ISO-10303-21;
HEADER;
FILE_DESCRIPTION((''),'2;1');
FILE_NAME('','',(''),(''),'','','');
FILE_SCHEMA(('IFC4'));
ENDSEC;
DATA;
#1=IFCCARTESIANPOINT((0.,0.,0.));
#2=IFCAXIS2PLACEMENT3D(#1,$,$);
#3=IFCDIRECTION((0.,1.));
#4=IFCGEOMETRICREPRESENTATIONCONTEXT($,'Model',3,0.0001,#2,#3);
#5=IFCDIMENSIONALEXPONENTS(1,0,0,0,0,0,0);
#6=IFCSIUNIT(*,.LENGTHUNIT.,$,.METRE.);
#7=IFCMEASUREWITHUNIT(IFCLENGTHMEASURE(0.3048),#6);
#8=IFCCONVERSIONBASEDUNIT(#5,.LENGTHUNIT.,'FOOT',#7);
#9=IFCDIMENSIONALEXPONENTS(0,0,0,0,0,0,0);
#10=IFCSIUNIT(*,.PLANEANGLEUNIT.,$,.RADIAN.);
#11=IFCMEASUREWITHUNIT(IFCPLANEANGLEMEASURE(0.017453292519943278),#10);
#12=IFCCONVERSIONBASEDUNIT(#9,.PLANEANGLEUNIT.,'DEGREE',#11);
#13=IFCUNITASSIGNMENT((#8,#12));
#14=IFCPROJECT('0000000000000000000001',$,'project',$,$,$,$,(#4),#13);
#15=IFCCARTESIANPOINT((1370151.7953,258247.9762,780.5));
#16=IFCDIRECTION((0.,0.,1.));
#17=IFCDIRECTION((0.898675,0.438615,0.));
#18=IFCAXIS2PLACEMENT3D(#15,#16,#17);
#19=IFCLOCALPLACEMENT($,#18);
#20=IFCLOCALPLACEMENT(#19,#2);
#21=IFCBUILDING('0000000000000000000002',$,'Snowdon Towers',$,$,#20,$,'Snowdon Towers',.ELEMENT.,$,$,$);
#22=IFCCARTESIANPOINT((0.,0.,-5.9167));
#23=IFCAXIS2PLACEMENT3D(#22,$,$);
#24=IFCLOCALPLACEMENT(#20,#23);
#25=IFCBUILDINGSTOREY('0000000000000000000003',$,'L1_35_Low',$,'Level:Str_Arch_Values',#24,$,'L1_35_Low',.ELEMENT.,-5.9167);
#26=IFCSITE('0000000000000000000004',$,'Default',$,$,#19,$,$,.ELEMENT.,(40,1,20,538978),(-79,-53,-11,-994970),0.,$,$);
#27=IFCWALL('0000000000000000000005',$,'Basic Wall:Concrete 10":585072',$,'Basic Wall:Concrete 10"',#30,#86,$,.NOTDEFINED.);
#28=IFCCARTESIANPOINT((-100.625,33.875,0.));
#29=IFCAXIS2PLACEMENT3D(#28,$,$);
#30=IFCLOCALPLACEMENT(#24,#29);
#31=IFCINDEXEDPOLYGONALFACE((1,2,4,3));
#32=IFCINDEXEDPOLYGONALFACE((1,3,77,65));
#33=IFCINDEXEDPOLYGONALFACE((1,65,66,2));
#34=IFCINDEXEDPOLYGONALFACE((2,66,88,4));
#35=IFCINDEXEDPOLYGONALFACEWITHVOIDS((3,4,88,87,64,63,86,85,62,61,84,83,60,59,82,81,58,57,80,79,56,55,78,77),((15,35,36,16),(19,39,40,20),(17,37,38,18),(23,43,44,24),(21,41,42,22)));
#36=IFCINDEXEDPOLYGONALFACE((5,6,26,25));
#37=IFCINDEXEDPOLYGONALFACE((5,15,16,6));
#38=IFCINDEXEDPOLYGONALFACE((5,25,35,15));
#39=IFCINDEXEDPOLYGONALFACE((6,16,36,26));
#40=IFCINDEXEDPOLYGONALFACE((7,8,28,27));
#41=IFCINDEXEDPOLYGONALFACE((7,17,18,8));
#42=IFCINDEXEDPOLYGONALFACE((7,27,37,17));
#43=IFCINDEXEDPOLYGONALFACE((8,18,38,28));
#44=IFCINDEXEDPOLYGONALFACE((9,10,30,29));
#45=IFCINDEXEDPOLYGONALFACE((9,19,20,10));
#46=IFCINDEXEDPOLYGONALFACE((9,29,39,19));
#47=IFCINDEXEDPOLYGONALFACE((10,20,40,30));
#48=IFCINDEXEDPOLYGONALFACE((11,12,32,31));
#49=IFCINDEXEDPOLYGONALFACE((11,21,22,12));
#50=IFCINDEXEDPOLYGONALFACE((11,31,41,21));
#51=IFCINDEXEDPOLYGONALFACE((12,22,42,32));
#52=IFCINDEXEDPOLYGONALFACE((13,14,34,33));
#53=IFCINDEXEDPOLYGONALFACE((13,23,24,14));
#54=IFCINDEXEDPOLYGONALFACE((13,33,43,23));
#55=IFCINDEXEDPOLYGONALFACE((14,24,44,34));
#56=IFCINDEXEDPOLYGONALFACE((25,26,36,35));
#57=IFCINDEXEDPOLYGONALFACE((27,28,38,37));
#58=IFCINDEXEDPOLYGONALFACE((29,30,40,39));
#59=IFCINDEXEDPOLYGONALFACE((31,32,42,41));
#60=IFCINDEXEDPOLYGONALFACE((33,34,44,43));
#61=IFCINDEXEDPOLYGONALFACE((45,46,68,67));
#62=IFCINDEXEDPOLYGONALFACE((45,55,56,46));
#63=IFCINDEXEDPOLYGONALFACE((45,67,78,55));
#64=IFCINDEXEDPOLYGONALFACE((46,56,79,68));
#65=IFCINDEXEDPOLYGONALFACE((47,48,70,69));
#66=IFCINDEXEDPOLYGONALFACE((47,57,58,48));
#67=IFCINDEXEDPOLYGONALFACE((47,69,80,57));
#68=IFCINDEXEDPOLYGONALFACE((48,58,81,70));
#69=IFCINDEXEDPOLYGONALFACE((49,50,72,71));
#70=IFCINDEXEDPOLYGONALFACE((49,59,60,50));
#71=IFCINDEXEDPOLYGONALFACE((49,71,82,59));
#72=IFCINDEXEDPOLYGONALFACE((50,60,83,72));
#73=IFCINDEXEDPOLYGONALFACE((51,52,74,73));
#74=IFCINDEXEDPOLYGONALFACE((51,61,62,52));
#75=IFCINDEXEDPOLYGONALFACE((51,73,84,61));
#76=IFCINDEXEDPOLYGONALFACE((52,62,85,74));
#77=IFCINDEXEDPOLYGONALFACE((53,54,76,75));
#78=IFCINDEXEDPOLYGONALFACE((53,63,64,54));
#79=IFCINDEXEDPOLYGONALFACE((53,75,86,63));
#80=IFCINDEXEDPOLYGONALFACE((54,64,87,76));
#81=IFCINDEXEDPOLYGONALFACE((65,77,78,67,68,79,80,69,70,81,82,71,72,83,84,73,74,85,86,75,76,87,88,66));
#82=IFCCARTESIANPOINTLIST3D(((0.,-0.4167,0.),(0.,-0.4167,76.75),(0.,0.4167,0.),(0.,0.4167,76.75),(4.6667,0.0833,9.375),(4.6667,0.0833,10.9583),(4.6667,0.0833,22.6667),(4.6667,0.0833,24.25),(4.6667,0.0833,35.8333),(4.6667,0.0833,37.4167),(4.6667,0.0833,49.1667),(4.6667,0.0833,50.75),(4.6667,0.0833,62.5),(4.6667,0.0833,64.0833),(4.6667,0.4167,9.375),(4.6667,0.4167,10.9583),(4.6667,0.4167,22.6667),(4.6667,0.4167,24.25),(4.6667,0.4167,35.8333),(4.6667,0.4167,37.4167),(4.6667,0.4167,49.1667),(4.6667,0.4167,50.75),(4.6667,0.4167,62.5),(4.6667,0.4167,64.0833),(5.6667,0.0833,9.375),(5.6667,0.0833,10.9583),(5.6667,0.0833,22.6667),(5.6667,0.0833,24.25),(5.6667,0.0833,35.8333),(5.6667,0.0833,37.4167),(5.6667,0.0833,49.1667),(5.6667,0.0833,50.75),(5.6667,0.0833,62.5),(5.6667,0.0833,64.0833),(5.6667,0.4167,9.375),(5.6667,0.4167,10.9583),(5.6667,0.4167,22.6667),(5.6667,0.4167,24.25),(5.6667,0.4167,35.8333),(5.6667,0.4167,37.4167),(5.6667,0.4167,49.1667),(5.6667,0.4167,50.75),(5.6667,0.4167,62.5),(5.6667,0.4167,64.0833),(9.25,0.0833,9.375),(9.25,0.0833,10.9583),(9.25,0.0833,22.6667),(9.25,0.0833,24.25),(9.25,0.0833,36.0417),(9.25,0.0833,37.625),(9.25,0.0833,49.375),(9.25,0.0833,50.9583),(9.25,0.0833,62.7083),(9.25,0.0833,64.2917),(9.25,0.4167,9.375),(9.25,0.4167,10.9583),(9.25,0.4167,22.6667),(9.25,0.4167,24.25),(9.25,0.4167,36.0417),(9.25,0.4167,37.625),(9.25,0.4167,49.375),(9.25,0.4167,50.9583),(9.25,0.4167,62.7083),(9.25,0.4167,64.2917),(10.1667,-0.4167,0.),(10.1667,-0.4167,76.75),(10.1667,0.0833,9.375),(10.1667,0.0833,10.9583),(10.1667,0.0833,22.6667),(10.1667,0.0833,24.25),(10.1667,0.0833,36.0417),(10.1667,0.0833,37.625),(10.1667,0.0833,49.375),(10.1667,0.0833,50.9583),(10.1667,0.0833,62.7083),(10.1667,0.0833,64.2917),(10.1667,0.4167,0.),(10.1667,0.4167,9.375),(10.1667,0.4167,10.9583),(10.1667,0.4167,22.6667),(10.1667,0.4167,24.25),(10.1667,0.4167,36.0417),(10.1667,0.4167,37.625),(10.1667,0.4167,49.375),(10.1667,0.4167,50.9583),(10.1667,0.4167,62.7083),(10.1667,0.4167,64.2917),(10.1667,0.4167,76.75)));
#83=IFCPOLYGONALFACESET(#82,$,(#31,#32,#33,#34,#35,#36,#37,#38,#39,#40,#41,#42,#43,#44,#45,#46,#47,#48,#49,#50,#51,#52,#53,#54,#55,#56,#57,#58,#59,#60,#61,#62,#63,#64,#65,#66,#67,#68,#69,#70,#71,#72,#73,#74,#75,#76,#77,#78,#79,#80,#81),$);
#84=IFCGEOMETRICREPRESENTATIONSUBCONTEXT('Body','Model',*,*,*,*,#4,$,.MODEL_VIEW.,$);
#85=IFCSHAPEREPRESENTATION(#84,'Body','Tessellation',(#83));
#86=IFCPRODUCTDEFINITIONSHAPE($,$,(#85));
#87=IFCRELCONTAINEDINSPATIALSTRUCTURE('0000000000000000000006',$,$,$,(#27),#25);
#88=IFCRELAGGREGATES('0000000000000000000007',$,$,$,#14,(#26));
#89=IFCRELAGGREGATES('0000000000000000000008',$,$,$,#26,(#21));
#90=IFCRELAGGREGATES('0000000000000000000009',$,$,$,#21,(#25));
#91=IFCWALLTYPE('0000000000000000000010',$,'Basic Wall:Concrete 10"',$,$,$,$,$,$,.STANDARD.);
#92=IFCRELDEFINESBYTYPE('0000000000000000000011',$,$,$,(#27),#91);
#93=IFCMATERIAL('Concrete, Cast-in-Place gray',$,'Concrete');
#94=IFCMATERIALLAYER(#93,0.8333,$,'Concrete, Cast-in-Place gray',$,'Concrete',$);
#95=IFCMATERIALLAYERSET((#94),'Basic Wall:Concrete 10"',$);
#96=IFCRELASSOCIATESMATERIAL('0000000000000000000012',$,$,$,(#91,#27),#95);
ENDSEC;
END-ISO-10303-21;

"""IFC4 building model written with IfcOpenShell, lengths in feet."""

from ifc_helpers import new_model, entity, si_unit, converted_unit, direction, frame, frame_2d, origin, place, context, subcontext, project, spatial, rectangle, extrude, material, layer, layer_set, layer_usage, type_object, element, save


model = new_model("IFC4")

# Units and contexts
model_context = context("Model", 3, precision=0.0001, world=origin(), true_north=direction((0.0, 1.0)))
body_context = subcontext(model_context, "Body", "Model", "MODEL_VIEW")
ifc_project = project(units=[converted_unit("LENGTHUNIT", "FOOT", entity("IfcLengthMeasure", 0.3048), si_unit("LENGTHUNIT", "METRE"), dimensions=[1, 0, 0, 0, 0, 0, 0]), converted_unit("PLANEANGLEUNIT", "DEGREE", entity("IfcPlaneAngleMeasure", 0.017453292519943278), si_unit("PLANEANGLEUNIT", "RADIAN"), dimensions=[0, 0, 0, 0, 0, 0, 0])], contexts=[model_context])

# Site, building, storey
site_placement = place(None, frame((1370151.7953, 258247.9762, 780.5), z_axis=(0.0, 0.0, 1.0), x_axis=(0.898675, 0.438615, 0.0)))
site = spatial("IfcSite", under=ifc_project, at=site_placement, Name="Default", CompositionType="ELEMENT", RefLatitude=(40, 1, 20, 538978), RefLongitude=(-79, -53, -11, -994970), RefElevation=0.0)
building_placement = place(site_placement, origin())
building = spatial("IfcBuilding", under=site, at=building_placement, Name="Snowdon Towers", LongName="Snowdon Towers", CompositionType="ELEMENT")
storey_placement = place(building_placement, frame((0.0, 0.0, -5.9167)))
storey = spatial("IfcBuildingStorey", under=building, at=storey_placement, Name="L1_35_Low", ObjectType="Level:Str_Arch_Values", LongName="L1_35_Low", CompositionType="ELEMENT", Elevation=-5.9167)

# Wall, openings
ifc_material = material(Name="Concrete, Cast-in-Place gray", Category="Concrete")
ifc_layer = layer(ifc_material, 0.8333, Name="Concrete, Cast-in-Place gray", Category="Concrete")
ifc_layer_set = layer_set([ifc_layer], Name="Basic Wall:Concrete 10\"")
ifc_layer_usage_1 = layer_usage(ifc_layer_set, "AXIS2", "POSITIVE", -0.4167)
wall_type = type_object("IfcWallType", Name="Basic Wall:Concrete 10\"", PredefinedType="STANDARD", material=ifc_layer_set)
wall_1_placement = place(storey_placement, frame((-100.625, 33.875, 0.0)))
wall_1 = element("IfcWall", 1, at=wall_1_placement, inside=storey, type_object=wall_type, material=ifc_layer_usage_1, Name="Basic Wall:Concrete 10\":585072", ObjectType="Basic Wall:Concrete 10\"", PredefinedType="NOTDEFINED", context=body_context, shape_type="SweptSolid", body=[
    extrude(rectangle(XDim=10.1667, YDim=0.8333, at=frame_2d((5.0833, 0.0), x_axis=(-1.0, 0.0))), origin(), (0.0, 0.0, 1.0), 76.75),
])
opening_1_placement = place(wall_1_placement, origin())
element("IfcOpeningElement", 2, at=opening_1_placement, cuts=wall_1, PredefinedType="RECESS", context=body_context, shape_type="SweptSolid", body=[
    extrude(rectangle(XDim=1.5833, YDim=1.0, at=frame_2d((0.0, 0.0), x_axis=(0.0, 1.0))), frame((9.75, 0.0833, 23.4583), z_axis=(0.0, 1.0, 0.0), x_axis=(1.0, 0.0, 0.0)), (0.0, 0.0, 1.0), 0.3333),
])
opening_2_placement = place(wall_1_placement, origin())
element("IfcOpeningElement", 3, at=opening_2_placement, cuts=wall_1, PredefinedType="RECESS", context=body_context, shape_type="SweptSolid", body=[
    extrude(rectangle(XDim=1.5833, YDim=1.0, at=frame_2d((0.0, 0.0), x_axis=(0.0, 1.0))), frame((9.75, 0.0833, 10.1667), z_axis=(0.0, 1.0, 0.0), x_axis=(1.0, 0.0, 0.0)), (0.0, 0.0, 1.0), 0.3333),
])
opening_3_placement = place(wall_1_placement, origin())
element("IfcOpeningElement", 4, at=opening_3_placement, cuts=wall_1, PredefinedType="RECESS", context=body_context, shape_type="SweptSolid", body=[
    extrude(rectangle(XDim=1.5833, YDim=1.0, at=frame_2d((0.0, 0.0), x_axis=(0.0, 1.0))), frame((9.75, 0.0833, 63.5), z_axis=(0.0, 1.0, 0.0), x_axis=(1.0, 0.0, 0.0)), (0.0, 0.0, 1.0), 0.3333),
])
opening_4_placement = place(wall_1_placement, origin())
element("IfcOpeningElement", 5, at=opening_4_placement, cuts=wall_1, PredefinedType="RECESS", context=body_context, shape_type="SweptSolid", body=[
    extrude(rectangle(XDim=1.5833, YDim=1.0, at=frame_2d((0.0, 0.0), x_axis=(0.0, 1.0))), frame((9.75, 0.0833, 36.8333), z_axis=(0.0, 1.0, 0.0), x_axis=(1.0, 0.0, 0.0)), (0.0, 0.0, 1.0), 0.3333),
])
opening_5_placement = place(wall_1_placement, origin())
element("IfcOpeningElement", 6, at=opening_5_placement, cuts=wall_1, PredefinedType="RECESS", context=body_context, shape_type="SweptSolid", body=[
    extrude(rectangle(XDim=1.5833, YDim=1.0, at=frame_2d((0.0, 0.0), x_axis=(0.0, 1.0))), frame((9.75, 0.0833, 50.1667), z_axis=(0.0, 1.0, 0.0), x_axis=(1.0, 0.0, 0.0)), (0.0, 0.0, 1.0), 0.3333),
])
opening_6_placement = place(wall_1_placement, origin())
element("IfcOpeningElement", 7, at=opening_6_placement, cuts=wall_1, PredefinedType="RECESS", context=body_context, shape_type="SweptSolid", body=[
    extrude(rectangle(XDim=1.5833, YDim=1.0, at=frame_2d((0.0, 0.0), x_axis=(0.0, 1.0))), frame((5.1667, 0.0833, 23.4583), z_axis=(0.0, 1.0, 0.0), x_axis=(1.0, 0.0, 0.0)), (0.0, 0.0, 1.0), 0.3333),
])
opening_7_placement = place(wall_1_placement, origin())
element("IfcOpeningElement", 8, at=opening_7_placement, cuts=wall_1, PredefinedType="RECESS", context=body_context, shape_type="SweptSolid", body=[
    extrude(rectangle(XDim=1.5833, YDim=1.0, at=frame_2d((0.0, 0.0), x_axis=(0.0, 1.0))), frame((5.1667, 0.0833, 10.1667), z_axis=(0.0, 1.0, 0.0), x_axis=(1.0, 0.0, 0.0)), (0.0, 0.0, 1.0), 0.3333),
])
opening_8_placement = place(wall_1_placement, origin())
element("IfcOpeningElement", 9, at=opening_8_placement, cuts=wall_1, PredefinedType="RECESS", context=body_context, shape_type="SweptSolid", body=[
    extrude(rectangle(XDim=1.5833, YDim=1.0, at=frame_2d((0.0, 0.0), x_axis=(0.0, 1.0))), frame((5.1667, 0.0833, 63.2917), z_axis=(0.0, 1.0, 0.0), x_axis=(1.0, 0.0, 0.0)), (0.0, 0.0, 1.0), 0.3333),
])
opening_9_placement = place(wall_1_placement, origin())
element("IfcOpeningElement", 10, at=opening_9_placement, cuts=wall_1, PredefinedType="RECESS", context=body_context, shape_type="SweptSolid", body=[
    extrude(rectangle(XDim=1.5833, YDim=1.0, at=frame_2d((0.0, 0.0), x_axis=(0.0, 1.0))), frame((5.1667, 0.0833, 36.625), z_axis=(0.0, 1.0, 0.0), x_axis=(1.0, 0.0, 0.0)), (0.0, 0.0, 1.0), 0.3333),
])
opening_10_placement = place(wall_1_placement, origin())
element("IfcOpeningElement", 11, at=opening_10_placement, cuts=wall_1, PredefinedType="RECESS", context=body_context, shape_type="SweptSolid", body=[
    extrude(rectangle(XDim=1.5833, YDim=1.0, at=frame_2d((0.0, 0.0), x_axis=(0.0, 1.0))), frame((5.1667, 0.0833, 49.9583), z_axis=(0.0, 1.0, 0.0), x_axis=(1.0, 0.0, 0.0)), (0.0, 0.0, 1.0), 0.3333),
])

save(model, "model.ifc")
